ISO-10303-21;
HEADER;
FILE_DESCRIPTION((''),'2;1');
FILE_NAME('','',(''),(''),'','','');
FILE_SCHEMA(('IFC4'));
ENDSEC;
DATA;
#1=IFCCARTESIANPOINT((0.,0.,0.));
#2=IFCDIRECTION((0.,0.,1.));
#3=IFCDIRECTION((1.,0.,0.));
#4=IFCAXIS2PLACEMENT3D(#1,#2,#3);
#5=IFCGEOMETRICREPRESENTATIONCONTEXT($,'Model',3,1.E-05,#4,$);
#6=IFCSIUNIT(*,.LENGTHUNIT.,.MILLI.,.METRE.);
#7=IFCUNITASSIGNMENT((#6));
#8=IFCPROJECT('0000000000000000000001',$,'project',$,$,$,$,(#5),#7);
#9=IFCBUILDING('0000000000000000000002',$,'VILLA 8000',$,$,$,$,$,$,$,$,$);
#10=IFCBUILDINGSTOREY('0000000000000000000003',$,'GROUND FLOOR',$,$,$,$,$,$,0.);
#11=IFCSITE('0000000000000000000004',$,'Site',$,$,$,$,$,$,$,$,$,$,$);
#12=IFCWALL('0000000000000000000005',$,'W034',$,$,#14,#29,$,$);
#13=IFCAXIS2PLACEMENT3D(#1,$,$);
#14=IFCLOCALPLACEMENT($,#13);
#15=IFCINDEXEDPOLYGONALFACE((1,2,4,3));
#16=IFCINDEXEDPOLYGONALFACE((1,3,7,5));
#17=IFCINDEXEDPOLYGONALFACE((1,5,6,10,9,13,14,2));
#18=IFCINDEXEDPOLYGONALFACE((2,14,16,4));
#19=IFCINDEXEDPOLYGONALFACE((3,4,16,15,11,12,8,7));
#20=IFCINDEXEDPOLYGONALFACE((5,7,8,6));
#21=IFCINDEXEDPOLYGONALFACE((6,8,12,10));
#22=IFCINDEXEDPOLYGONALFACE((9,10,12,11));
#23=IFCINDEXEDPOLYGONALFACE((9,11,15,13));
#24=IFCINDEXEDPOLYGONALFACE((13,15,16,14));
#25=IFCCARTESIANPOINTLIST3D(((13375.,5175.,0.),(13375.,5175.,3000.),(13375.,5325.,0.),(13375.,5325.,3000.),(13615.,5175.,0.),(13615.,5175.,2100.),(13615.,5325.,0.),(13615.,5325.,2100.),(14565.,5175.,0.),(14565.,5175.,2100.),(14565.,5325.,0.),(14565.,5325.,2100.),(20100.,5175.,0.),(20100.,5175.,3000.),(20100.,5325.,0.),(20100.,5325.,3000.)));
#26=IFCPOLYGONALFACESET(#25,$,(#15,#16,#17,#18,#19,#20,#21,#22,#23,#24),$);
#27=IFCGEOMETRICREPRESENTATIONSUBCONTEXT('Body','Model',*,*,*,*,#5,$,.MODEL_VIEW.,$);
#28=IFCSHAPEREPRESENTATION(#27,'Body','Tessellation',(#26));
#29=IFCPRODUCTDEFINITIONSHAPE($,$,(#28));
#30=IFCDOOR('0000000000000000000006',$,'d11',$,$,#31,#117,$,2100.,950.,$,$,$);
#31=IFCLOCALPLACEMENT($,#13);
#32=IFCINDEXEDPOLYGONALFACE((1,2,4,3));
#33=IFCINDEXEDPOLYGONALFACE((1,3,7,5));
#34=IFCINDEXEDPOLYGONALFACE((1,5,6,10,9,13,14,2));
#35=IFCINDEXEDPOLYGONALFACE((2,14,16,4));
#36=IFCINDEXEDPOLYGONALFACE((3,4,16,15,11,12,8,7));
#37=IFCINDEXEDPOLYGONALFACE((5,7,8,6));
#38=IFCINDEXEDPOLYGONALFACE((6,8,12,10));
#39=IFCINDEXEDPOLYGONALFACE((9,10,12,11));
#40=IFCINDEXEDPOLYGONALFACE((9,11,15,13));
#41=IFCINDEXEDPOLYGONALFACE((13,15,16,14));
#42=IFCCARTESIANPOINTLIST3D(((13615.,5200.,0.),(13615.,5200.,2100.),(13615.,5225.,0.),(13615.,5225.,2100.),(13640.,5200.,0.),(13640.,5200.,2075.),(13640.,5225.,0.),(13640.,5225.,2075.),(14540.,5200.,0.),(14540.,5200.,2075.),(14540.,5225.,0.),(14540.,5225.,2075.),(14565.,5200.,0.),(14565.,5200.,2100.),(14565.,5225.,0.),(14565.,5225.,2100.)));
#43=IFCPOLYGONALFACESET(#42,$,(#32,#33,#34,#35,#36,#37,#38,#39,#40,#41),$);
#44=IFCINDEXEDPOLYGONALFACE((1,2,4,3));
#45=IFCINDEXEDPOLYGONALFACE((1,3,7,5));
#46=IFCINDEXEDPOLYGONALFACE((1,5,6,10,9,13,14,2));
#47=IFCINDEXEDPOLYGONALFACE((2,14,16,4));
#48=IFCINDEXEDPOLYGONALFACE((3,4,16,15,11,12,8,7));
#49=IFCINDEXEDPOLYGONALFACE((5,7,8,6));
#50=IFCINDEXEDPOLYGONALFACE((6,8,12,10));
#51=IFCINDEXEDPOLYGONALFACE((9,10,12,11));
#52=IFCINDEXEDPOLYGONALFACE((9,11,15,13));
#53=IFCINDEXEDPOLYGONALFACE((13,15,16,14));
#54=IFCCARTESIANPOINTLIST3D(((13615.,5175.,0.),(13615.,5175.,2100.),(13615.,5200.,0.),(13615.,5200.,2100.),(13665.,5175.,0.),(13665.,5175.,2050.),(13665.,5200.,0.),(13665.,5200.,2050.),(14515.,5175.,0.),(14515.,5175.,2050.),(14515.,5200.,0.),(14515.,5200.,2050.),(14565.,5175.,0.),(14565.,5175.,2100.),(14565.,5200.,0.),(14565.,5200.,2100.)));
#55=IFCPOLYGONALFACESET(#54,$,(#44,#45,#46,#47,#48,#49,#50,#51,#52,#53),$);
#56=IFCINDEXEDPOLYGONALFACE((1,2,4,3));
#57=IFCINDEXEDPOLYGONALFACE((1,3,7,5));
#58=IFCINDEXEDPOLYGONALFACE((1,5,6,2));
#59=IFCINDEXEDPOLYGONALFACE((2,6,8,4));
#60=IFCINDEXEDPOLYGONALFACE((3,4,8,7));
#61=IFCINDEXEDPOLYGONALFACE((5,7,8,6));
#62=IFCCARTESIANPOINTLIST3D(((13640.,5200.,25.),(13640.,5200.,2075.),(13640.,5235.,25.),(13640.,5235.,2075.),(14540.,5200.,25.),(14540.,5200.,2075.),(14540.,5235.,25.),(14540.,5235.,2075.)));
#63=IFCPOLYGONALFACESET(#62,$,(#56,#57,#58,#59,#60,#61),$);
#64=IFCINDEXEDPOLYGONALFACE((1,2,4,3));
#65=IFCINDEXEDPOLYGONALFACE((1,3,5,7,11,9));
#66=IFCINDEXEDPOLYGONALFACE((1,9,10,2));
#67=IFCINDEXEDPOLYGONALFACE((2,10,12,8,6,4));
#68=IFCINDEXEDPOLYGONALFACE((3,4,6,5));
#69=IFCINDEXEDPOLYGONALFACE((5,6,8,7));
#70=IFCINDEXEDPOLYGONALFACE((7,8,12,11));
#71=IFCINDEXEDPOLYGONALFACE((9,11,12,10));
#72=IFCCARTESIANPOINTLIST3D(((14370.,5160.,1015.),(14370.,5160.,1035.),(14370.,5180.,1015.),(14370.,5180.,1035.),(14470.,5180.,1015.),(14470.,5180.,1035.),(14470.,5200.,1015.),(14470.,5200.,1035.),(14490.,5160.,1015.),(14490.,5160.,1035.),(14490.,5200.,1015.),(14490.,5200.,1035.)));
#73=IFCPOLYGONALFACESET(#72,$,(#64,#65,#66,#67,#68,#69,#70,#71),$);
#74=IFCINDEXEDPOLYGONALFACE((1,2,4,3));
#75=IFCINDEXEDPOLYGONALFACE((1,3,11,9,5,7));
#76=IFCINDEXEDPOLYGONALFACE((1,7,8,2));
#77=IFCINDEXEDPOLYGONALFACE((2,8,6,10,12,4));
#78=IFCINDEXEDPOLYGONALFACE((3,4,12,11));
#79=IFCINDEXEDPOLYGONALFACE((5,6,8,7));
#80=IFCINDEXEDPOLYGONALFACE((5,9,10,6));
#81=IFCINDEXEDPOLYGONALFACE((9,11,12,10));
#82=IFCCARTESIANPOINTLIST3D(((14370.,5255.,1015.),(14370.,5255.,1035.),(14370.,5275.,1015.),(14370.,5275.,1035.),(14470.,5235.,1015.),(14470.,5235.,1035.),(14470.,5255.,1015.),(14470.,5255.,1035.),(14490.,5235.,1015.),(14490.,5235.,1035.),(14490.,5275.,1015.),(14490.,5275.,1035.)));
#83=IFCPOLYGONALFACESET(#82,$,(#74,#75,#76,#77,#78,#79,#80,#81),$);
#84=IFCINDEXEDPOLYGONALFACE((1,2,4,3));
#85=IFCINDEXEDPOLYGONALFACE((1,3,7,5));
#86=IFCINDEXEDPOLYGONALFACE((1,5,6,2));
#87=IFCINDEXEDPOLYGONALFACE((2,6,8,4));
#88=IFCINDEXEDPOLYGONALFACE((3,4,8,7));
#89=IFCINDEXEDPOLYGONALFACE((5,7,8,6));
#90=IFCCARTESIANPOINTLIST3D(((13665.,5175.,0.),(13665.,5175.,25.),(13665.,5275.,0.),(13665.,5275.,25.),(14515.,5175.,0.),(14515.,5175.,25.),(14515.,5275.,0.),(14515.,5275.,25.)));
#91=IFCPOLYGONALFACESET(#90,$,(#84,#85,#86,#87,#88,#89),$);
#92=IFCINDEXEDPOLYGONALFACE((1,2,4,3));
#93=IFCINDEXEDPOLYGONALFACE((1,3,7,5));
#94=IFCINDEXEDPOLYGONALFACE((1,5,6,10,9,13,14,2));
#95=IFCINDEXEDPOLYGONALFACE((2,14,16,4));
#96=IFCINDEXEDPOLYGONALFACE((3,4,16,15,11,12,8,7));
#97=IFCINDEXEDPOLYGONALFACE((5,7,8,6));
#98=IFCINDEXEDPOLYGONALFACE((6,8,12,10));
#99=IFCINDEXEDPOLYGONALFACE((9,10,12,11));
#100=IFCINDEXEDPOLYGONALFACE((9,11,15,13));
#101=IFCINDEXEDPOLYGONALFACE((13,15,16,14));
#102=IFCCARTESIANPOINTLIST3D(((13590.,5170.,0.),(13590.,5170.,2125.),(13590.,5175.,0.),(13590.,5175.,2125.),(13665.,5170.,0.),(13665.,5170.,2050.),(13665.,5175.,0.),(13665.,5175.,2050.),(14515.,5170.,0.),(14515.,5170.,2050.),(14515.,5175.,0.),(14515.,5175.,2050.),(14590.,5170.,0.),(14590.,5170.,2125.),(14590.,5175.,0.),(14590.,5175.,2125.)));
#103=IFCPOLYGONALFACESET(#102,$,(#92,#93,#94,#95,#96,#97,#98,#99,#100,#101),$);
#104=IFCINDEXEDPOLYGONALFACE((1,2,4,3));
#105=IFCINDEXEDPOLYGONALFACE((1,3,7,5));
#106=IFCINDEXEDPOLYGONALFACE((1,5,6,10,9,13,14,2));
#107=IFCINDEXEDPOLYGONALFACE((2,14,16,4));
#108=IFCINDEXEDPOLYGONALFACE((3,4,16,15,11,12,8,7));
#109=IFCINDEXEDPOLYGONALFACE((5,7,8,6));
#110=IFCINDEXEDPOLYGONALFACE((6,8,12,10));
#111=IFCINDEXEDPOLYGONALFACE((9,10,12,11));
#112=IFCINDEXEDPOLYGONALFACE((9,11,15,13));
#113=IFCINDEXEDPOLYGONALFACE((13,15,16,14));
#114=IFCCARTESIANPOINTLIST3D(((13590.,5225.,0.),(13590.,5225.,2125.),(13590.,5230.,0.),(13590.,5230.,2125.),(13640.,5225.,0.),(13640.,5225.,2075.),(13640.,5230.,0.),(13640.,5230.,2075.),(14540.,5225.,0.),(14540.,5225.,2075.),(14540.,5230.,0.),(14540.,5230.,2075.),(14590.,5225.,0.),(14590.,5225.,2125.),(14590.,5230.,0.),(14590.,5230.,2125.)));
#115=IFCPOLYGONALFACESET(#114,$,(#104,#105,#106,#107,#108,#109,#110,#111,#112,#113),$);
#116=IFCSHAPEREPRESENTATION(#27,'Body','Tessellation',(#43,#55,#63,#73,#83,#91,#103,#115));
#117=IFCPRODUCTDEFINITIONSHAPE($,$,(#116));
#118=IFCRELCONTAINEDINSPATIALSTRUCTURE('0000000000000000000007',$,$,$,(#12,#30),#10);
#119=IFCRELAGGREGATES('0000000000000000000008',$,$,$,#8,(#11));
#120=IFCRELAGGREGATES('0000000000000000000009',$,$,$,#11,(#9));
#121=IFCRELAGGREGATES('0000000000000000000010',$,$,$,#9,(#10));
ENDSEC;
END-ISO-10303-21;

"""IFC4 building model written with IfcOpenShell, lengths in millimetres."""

from ifc_helpers import new_model, si_unit, frame, origin_with_axes, place, context, subcontext, project, spatial, line, indexed_curve, outline, extrude, element, fill, save


model = new_model("IFC4")

# Units and contexts
model_context = context("Model", 3, precision=1e-05, world=origin_with_axes())
body_context = subcontext(model_context, "Body", "Model", "MODEL_VIEW")
ifc_project = project(units=[si_unit("LENGTHUNIT", "METRE", prefix="MILLI")], contexts=[model_context])

# Site, building, storey
site = spatial("IfcSite", under=ifc_project, Name="Site")
building = spatial("IfcBuilding", under=site, Name="VILLA 8000")
storey = spatial("IfcBuildingStorey", under=building, Name="GROUND FLOOR", Elevation=0.0)

# Wall, opening, door
wall_1_placement = place(None, frame((13375.0, 5250.0, 0.0), z_axis=(0.0, 0.0, 1.0), x_axis=(1.0, 0.0, 0.0)))
wall_1 = element("IfcWall", 1, at=wall_1_placement, inside=storey, Name="W034", context=body_context, shape_type="SweptSolid", body=[
    extrude(outline(indexed_curve([(0.0, 0.0), (0.0, 150.0), (6725.0, 150.0), (6725.0, 0.0), (0.0, 0.0)], self_intersect=False)), frame((0.0, -75.0, 0.0), z_axis=(0.0, 0.0, 1.0), x_axis=(1.0, 0.0, 0.0)), (0.0, 0.0, 1.0), 3000.0),
])
opening_1_placement = place(wall_1_placement, frame((240.0, 0.0, 0.0), z_axis=(0.0, 0.0, 1.0), x_axis=(1.0, 0.0, 0.0)))
opening_1 = element("IfcOpeningElement", 2, at=opening_1_placement, cuts=wall_1, context=body_context, shape_type="SweptSolid", body=[
    extrude(outline(indexed_curve([(0.0, 0.0), (0.0, 250.0), (950.0, 250.0), (950.0, 0.0), (0.0, 0.0)], self_intersect=False)), frame((0.0, -125.0, 0.0), z_axis=(0.0, 0.0, 1.0), x_axis=(1.0, 0.0, 0.0)), (0.0, 0.0, 1.0), 2100.0),
])
door_1_placement = place(None, frame((13615.0, 5175.0, 0.0), z_axis=(0.0, 0.0, 1.0), x_axis=(1.0, 0.0, 0.0)))
door_1 = element("IfcDoor", 3, at=door_1_placement, inside=storey, Name="d11", OverallHeight=2100.0, OverallWidth=950.0, context=body_context, shape_type="SweptSolid", body=[
    extrude(outline(indexed_curve([(0.0, 0.0), (0.0, 2100.0), (950.0, 2100.0), (950.0, 0.0), (925.0, 0.0), (925.0, 2075.0), (25.0, 2075.0), (25.0, 0.0)], segments=[line(1, 2, 3, 4, 5, 6, 7, 8, 1)])), frame((0.0, 25.0, 0.0), z_axis=(0.0, -1.0, 0.0), x_axis=(1.0, 0.0, 0.0)), (0.0, 0.0, -1.0), 25.0),
    extrude(outline(indexed_curve([(0.0, 0.0), (0.0, 2100.0), (950.0, 2100.0), (950.0, 0.0), (900.0, 0.0), (900.0, 2050.0), (50.0, 2050.0), (50.0, 0.0)], segments=[line(1, 2, 3, 4, 5, 6, 7, 8, 1)])), frame((0.0, 0.0, 0.0), z_axis=(0.0, -1.0, 0.0), x_axis=(1.0, 0.0, 0.0)), (0.0, 0.0, -1.0), 25.0),
    extrude(outline(indexed_curve([(0.0, 0.0), (900.0, 0.0), (900.0, 35.0), (0.0, 35.0)], segments=[line(1, 2, 3, 4, 1)])), frame((25.0, 25.0, 25.0), z_axis=(0.0, 0.0, 1.0), x_axis=(1.0, 0.0, 0.0)), (0.0, 0.0, 1.0), 2050.0),
    extrude(outline(indexed_curve([(0.0, 0.0), (0.0, -40.0), (-120.0, -40.0), (-120.0, -20.0), (-20.0, -20.0), (-20.0, 0.0)], segments=[line(1, 2, 3, 4, 5, 6, 1)])), frame((875.0, 25.0, 1015.0), z_axis=(0.0, 0.0, 1.0), x_axis=(1.0, 0.0, 0.0)), (0.0, 0.0, 1.0), 20.0),
    extrude(outline(indexed_curve([(0.0, 0.0), (0.0, 40.0), (-120.0, 40.0), (-120.0, 20.0), (-20.0, 20.0), (-20.0, 0.0)], segments=[line(1, 2, 3, 4, 5, 6, 1)])), frame((875.0, 60.0, 1015.0), z_axis=(0.0, 0.0, 1.0), x_axis=(1.0, 0.0, 0.0)), (0.0, 0.0, 1.0), 20.0),
    extrude(outline(indexed_curve([(0.0, 0.0), (850.0, 0.0), (850.0, 100.0), (0.0, 100.0)], segments=[line(1, 2, 3, 4, 1)])), frame((50.0, 0.0, 0.0), z_axis=(0.0, 0.0, 1.0), x_axis=(1.0, 0.0, 0.0)), (0.0, 0.0, 1.0), 25.0),
    extrude(outline(indexed_curve([(0.0, 0.0), (0.0, 2125.0), (1000.0, 2125.0), (1000.0, 0.0), (925.0, 0.0), (925.0, 2050.0), (75.0, 2050.0), (75.0, 0.0)], segments=[line(1, 2, 3, 4, 5, 6, 7, 8, 1)])), frame((-25.0, -5.0, 0.0), z_axis=(0.0, -1.0, 0.0), x_axis=(1.0, 0.0, 0.0)), (0.0, 0.0, -1.0), 5.0),
    extrude(outline(indexed_curve([(0.0, 0.0), (0.0, 2125.0), (1000.0, 2125.0), (1000.0, 0.0), (950.0, 0.0), (950.0, 2075.0), (50.0, 2075.0), (50.0, 0.0)], segments=[line(1, 2, 3, 4, 5, 6, 7, 8, 1)])), frame((-25.0, 50.0, 0.0), z_axis=(0.0, -1.0, 0.0), x_axis=(1.0, 0.0, 0.0)), (0.0, 0.0, -1.0), 5.0),
])
fill(opening_1, door_1)

save(model, "model.ifc")
